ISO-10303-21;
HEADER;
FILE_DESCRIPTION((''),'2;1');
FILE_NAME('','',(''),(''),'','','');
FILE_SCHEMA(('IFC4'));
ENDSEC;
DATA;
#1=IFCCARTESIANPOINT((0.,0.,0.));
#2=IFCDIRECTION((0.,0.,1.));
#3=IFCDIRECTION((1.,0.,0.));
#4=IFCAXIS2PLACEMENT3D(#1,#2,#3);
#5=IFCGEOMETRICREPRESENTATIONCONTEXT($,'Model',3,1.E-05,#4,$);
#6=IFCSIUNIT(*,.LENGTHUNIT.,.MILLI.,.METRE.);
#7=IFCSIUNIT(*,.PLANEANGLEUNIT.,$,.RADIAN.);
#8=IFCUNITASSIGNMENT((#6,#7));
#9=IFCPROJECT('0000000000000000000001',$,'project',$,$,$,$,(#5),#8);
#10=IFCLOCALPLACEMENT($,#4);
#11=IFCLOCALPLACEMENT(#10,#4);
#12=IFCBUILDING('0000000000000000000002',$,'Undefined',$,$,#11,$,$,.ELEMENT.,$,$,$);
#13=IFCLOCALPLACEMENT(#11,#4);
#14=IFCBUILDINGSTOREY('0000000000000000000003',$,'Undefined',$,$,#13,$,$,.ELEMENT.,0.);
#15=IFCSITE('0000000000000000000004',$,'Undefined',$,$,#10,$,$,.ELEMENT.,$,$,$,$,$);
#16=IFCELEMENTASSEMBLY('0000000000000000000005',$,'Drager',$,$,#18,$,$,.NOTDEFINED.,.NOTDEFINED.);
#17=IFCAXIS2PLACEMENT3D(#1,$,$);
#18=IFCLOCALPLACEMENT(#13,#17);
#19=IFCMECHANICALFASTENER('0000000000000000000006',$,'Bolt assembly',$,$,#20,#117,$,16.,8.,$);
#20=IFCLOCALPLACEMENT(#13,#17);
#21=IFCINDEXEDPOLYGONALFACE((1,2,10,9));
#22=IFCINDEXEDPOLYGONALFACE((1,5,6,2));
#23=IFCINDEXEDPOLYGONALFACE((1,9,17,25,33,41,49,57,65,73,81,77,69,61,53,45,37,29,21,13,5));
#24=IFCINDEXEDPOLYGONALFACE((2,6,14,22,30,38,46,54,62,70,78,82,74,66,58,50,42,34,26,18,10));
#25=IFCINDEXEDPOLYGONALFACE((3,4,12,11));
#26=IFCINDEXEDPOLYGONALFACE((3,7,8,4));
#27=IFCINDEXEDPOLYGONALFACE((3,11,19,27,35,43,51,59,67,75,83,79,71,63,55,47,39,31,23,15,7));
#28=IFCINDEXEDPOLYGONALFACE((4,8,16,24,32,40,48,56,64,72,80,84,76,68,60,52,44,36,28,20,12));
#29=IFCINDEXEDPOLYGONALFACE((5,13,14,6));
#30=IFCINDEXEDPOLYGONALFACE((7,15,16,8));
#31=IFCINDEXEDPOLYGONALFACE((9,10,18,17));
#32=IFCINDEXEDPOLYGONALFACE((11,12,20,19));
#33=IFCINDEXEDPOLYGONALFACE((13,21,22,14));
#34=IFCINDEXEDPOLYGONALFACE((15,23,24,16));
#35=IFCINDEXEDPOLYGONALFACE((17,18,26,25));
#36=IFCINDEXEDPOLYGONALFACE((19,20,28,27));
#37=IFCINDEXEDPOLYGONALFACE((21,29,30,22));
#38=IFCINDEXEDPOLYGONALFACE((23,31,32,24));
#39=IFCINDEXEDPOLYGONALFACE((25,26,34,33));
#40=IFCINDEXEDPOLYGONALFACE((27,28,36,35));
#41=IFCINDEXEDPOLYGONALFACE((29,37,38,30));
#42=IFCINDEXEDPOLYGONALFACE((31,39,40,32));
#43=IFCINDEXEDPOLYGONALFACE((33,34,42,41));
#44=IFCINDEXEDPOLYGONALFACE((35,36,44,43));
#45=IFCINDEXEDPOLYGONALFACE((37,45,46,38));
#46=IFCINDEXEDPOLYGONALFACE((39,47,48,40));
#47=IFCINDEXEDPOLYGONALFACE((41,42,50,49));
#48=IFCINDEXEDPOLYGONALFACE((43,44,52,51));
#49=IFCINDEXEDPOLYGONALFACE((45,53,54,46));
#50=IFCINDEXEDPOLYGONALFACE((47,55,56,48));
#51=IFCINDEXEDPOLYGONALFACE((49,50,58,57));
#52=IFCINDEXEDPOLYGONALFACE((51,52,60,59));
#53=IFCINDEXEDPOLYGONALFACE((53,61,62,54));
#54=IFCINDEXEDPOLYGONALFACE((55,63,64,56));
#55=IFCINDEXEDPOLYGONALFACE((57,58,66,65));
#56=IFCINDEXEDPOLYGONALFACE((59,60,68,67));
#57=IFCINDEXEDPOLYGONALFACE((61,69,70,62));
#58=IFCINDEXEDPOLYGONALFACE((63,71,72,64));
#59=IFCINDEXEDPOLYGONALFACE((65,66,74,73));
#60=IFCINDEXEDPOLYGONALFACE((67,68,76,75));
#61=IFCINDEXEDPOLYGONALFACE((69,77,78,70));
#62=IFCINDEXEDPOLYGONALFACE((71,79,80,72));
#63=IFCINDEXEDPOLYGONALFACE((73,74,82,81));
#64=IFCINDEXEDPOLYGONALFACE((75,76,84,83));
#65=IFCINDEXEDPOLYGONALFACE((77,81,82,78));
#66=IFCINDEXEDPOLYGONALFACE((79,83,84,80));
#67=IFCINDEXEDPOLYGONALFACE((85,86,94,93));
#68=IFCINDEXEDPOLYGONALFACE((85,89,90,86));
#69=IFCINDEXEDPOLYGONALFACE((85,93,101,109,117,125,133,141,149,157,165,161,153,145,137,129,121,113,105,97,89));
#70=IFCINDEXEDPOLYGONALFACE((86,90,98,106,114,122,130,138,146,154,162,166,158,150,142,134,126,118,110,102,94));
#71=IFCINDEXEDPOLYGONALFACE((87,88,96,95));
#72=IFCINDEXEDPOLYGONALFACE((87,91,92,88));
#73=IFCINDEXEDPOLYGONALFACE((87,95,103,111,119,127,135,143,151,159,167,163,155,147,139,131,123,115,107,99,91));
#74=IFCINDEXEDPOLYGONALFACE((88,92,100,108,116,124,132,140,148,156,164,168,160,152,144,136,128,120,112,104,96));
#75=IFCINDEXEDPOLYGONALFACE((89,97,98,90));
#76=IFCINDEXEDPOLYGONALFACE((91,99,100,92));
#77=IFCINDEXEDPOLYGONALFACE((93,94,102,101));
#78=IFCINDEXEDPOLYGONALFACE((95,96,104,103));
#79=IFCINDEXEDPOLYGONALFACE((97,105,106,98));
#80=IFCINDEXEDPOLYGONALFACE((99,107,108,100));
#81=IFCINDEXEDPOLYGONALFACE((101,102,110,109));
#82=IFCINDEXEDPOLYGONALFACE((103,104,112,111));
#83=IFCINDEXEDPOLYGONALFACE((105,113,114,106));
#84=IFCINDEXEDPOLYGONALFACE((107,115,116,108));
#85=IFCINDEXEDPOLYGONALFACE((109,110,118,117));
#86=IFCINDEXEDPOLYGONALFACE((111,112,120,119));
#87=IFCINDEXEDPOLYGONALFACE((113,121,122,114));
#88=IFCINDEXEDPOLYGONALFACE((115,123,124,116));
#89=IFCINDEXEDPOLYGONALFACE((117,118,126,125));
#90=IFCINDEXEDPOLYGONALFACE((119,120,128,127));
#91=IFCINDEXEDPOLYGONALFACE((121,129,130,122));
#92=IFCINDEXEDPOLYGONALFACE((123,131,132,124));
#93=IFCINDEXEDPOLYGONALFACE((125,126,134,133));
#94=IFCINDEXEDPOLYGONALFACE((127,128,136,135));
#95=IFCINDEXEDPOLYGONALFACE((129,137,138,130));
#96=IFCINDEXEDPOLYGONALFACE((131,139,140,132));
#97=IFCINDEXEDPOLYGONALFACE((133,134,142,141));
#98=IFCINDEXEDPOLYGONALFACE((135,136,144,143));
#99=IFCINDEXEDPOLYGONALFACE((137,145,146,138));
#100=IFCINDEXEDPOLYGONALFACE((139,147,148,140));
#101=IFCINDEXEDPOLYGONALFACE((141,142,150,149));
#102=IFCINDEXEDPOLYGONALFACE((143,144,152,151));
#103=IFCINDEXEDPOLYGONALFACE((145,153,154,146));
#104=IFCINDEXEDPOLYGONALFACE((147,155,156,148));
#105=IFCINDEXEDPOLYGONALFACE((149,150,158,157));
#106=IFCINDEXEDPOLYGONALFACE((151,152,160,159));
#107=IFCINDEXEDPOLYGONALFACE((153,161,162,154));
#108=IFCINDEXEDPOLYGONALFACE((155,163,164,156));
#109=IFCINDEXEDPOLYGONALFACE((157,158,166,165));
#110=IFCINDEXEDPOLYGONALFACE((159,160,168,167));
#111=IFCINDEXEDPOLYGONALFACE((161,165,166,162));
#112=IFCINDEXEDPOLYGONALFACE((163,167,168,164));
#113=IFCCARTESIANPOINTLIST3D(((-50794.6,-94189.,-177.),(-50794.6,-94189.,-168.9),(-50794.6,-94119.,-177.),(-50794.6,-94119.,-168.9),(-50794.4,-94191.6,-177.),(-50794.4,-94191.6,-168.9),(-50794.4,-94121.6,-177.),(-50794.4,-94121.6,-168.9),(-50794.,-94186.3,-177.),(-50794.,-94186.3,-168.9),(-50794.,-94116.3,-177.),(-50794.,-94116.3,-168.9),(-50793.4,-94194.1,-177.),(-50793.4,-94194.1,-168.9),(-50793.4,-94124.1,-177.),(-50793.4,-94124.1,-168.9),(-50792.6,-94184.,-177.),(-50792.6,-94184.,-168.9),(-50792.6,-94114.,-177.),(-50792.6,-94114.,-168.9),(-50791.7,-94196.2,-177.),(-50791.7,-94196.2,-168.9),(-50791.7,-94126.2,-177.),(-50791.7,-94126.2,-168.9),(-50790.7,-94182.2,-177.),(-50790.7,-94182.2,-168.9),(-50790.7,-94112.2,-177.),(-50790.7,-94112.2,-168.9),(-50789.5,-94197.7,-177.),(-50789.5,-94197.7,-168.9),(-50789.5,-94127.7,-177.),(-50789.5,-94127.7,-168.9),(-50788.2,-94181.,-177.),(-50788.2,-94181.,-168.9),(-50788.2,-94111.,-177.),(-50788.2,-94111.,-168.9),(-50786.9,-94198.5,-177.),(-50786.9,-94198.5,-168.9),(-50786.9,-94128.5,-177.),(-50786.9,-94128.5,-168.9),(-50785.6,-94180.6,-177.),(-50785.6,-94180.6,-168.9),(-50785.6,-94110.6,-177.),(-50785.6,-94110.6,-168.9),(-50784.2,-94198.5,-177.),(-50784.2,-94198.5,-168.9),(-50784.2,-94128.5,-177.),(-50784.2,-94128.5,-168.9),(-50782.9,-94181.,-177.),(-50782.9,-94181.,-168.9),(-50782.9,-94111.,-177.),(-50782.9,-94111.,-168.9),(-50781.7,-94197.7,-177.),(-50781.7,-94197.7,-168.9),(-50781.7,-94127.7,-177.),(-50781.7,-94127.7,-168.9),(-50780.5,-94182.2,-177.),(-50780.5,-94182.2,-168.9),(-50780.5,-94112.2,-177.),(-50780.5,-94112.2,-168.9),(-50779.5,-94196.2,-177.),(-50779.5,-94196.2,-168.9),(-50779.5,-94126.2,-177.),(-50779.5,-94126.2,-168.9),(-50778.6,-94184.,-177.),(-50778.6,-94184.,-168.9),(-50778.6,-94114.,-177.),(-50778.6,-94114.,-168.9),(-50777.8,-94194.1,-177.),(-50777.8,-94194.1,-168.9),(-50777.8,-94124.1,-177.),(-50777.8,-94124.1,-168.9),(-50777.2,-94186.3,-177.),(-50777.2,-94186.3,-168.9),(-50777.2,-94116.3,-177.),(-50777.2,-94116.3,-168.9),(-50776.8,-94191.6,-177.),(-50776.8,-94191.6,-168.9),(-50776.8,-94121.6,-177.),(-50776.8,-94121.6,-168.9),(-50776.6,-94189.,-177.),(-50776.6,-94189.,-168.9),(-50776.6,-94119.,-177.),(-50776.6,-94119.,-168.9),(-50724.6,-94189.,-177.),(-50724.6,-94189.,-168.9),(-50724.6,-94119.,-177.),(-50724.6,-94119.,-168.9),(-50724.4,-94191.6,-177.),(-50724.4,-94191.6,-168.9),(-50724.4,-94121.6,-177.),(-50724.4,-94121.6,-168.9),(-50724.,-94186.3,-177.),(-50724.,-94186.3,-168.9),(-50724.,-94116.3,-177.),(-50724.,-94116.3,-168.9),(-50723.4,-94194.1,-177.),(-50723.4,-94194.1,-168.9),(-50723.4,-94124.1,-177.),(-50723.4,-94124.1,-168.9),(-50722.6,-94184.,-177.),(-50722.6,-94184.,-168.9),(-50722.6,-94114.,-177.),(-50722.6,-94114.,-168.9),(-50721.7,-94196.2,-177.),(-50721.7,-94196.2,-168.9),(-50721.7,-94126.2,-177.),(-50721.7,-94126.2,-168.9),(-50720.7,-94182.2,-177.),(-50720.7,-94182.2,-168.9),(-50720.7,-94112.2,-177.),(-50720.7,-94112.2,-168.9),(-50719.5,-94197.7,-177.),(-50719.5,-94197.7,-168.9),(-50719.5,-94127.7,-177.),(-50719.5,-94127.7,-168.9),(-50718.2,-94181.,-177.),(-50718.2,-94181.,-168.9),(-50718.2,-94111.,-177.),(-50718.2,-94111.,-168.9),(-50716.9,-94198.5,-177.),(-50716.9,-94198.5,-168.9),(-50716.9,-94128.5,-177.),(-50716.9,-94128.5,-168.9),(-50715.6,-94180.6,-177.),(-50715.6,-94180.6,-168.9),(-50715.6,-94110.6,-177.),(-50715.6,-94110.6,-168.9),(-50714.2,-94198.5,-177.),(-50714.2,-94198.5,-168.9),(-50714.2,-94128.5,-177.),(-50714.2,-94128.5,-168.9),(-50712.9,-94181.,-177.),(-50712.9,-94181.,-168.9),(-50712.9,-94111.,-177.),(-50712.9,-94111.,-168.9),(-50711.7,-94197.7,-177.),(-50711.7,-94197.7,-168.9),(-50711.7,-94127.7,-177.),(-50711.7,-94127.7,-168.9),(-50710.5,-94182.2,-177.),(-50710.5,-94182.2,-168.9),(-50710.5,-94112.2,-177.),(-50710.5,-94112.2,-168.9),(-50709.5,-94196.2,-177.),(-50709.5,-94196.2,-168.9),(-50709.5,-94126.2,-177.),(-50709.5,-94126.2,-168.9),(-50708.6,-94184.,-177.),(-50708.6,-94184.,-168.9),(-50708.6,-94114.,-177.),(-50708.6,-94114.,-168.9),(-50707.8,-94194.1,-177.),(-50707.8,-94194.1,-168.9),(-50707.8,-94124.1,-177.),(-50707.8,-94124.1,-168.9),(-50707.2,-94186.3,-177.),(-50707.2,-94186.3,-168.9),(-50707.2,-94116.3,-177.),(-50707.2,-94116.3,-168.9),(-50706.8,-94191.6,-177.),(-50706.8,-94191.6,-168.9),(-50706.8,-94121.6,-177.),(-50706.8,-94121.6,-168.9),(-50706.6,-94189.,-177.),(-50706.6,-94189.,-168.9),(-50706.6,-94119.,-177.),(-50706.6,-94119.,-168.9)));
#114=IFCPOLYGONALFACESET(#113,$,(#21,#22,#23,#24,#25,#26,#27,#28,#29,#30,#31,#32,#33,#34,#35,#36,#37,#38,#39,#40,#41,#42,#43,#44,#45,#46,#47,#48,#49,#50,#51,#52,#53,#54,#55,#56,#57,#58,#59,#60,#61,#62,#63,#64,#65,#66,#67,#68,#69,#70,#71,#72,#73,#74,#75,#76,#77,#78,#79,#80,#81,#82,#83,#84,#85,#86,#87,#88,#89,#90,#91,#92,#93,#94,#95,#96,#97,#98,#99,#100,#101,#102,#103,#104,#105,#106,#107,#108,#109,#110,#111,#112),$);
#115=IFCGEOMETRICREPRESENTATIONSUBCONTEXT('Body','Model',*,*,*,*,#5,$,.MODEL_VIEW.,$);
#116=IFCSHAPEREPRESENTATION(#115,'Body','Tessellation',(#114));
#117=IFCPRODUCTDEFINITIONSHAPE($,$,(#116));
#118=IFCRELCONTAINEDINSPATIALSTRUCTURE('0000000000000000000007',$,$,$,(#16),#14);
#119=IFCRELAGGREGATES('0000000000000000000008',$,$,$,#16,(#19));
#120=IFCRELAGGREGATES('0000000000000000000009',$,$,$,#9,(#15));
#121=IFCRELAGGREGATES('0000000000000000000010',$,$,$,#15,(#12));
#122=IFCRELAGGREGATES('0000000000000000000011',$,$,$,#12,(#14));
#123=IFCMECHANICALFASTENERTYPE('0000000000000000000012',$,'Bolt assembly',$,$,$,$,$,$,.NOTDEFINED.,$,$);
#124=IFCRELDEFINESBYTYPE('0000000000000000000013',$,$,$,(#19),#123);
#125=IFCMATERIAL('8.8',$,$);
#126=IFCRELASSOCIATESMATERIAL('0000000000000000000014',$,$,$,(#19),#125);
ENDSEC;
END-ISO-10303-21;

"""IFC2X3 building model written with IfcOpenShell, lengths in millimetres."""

from ifc_helpers import new_model, si_unit, frame, origin_with_axes, origin_2d_with_axis, place, context, subcontext, project, spatial, circle, extrude, source, transform, mapped, material, type_object, element, aggregate, save


model = new_model("IFC2X3")

# Units and contexts
model_context = context("Model", 3, precision=1e-05, world=origin_with_axes())
body_context = subcontext(model_context, "Body", "Model", "MODEL_VIEW")
ifc_project = project(units=[si_unit("LENGTHUNIT", "METRE", prefix="MILLI"), si_unit("PLANEANGLEUNIT", "RADIAN")], contexts=[model_context])

# Site, building, storey
site_placement = place(None, origin_with_axes())
site = spatial("IfcSite", under=ifc_project, at=site_placement, Name="Undefined", CompositionType="ELEMENT")
building_placement = place(site_placement, origin_with_axes())
building = spatial("IfcBuilding", under=site, at=building_placement, Name="Undefined", CompositionType="ELEMENT")
storey_placement = place(building_placement, origin_with_axes())
storey = spatial("IfcBuildingStorey", under=building, at=storey_placement, Name="Undefined", CompositionType="ELEMENT", Elevation=0.0)

# Element assembly
assembly_1_placement = place(storey_placement, origin_with_axes())
assembly_1 = element("IfcElementAssembly", 1, at=assembly_1_placement, inside=storey, Name="Drager", AssemblyPlace="NOTDEFINED", PredefinedType="NOTDEFINED")

# Mechanical fastener
ifc_material_1 = material(Name="8.8")
mechanical_fastener_type = type_object("IfcMechanicalFastenerType", Name="Bolt assembly")
shared_shape_1 = source(origin_with_axes(), body_context, "Body", "SweptSolid", [
    extrude(circle(Radius=9.0, at=origin_2d_with_axis()), frame((0.0, 0.0, 0.0), z_axis=(0.0, 1.0, 0.0), x_axis=(1.0, 0.0, 0.0)), (0.0, 0.0, 1.0), 8.1),
])
mechanical_fastener_1_placement = place(assembly_1_placement, frame((-50750.6, -94189.6, -177.0), z_axis=(1.0, 0.0, 0.0), x_axis=(0.0, 1.0, 0.0)))
mechanical_fastener_1 = element("IfcMechanicalFastener", 2, at=mechanical_fastener_1_placement, type_object=mechanical_fastener_type, material=ifc_material_1, Name="Bolt assembly", NominalDiameter=16.0, NominalLength=8.0, context=body_context, shape_type="MappedRepresentation", body=[
    mapped(shared_shape_1, transform((0.0, 0.0, -35.0))),
    mapped(shared_shape_1, transform((70.0, 0.0, -35.0))),
    mapped(shared_shape_1, transform((0.0, 0.0, 35.0))),
    mapped(shared_shape_1, transform((70.0, 0.0, 35.0))),
])
aggregate(assembly_1, [mechanical_fastener_1])

save(model, "model.ifc")
